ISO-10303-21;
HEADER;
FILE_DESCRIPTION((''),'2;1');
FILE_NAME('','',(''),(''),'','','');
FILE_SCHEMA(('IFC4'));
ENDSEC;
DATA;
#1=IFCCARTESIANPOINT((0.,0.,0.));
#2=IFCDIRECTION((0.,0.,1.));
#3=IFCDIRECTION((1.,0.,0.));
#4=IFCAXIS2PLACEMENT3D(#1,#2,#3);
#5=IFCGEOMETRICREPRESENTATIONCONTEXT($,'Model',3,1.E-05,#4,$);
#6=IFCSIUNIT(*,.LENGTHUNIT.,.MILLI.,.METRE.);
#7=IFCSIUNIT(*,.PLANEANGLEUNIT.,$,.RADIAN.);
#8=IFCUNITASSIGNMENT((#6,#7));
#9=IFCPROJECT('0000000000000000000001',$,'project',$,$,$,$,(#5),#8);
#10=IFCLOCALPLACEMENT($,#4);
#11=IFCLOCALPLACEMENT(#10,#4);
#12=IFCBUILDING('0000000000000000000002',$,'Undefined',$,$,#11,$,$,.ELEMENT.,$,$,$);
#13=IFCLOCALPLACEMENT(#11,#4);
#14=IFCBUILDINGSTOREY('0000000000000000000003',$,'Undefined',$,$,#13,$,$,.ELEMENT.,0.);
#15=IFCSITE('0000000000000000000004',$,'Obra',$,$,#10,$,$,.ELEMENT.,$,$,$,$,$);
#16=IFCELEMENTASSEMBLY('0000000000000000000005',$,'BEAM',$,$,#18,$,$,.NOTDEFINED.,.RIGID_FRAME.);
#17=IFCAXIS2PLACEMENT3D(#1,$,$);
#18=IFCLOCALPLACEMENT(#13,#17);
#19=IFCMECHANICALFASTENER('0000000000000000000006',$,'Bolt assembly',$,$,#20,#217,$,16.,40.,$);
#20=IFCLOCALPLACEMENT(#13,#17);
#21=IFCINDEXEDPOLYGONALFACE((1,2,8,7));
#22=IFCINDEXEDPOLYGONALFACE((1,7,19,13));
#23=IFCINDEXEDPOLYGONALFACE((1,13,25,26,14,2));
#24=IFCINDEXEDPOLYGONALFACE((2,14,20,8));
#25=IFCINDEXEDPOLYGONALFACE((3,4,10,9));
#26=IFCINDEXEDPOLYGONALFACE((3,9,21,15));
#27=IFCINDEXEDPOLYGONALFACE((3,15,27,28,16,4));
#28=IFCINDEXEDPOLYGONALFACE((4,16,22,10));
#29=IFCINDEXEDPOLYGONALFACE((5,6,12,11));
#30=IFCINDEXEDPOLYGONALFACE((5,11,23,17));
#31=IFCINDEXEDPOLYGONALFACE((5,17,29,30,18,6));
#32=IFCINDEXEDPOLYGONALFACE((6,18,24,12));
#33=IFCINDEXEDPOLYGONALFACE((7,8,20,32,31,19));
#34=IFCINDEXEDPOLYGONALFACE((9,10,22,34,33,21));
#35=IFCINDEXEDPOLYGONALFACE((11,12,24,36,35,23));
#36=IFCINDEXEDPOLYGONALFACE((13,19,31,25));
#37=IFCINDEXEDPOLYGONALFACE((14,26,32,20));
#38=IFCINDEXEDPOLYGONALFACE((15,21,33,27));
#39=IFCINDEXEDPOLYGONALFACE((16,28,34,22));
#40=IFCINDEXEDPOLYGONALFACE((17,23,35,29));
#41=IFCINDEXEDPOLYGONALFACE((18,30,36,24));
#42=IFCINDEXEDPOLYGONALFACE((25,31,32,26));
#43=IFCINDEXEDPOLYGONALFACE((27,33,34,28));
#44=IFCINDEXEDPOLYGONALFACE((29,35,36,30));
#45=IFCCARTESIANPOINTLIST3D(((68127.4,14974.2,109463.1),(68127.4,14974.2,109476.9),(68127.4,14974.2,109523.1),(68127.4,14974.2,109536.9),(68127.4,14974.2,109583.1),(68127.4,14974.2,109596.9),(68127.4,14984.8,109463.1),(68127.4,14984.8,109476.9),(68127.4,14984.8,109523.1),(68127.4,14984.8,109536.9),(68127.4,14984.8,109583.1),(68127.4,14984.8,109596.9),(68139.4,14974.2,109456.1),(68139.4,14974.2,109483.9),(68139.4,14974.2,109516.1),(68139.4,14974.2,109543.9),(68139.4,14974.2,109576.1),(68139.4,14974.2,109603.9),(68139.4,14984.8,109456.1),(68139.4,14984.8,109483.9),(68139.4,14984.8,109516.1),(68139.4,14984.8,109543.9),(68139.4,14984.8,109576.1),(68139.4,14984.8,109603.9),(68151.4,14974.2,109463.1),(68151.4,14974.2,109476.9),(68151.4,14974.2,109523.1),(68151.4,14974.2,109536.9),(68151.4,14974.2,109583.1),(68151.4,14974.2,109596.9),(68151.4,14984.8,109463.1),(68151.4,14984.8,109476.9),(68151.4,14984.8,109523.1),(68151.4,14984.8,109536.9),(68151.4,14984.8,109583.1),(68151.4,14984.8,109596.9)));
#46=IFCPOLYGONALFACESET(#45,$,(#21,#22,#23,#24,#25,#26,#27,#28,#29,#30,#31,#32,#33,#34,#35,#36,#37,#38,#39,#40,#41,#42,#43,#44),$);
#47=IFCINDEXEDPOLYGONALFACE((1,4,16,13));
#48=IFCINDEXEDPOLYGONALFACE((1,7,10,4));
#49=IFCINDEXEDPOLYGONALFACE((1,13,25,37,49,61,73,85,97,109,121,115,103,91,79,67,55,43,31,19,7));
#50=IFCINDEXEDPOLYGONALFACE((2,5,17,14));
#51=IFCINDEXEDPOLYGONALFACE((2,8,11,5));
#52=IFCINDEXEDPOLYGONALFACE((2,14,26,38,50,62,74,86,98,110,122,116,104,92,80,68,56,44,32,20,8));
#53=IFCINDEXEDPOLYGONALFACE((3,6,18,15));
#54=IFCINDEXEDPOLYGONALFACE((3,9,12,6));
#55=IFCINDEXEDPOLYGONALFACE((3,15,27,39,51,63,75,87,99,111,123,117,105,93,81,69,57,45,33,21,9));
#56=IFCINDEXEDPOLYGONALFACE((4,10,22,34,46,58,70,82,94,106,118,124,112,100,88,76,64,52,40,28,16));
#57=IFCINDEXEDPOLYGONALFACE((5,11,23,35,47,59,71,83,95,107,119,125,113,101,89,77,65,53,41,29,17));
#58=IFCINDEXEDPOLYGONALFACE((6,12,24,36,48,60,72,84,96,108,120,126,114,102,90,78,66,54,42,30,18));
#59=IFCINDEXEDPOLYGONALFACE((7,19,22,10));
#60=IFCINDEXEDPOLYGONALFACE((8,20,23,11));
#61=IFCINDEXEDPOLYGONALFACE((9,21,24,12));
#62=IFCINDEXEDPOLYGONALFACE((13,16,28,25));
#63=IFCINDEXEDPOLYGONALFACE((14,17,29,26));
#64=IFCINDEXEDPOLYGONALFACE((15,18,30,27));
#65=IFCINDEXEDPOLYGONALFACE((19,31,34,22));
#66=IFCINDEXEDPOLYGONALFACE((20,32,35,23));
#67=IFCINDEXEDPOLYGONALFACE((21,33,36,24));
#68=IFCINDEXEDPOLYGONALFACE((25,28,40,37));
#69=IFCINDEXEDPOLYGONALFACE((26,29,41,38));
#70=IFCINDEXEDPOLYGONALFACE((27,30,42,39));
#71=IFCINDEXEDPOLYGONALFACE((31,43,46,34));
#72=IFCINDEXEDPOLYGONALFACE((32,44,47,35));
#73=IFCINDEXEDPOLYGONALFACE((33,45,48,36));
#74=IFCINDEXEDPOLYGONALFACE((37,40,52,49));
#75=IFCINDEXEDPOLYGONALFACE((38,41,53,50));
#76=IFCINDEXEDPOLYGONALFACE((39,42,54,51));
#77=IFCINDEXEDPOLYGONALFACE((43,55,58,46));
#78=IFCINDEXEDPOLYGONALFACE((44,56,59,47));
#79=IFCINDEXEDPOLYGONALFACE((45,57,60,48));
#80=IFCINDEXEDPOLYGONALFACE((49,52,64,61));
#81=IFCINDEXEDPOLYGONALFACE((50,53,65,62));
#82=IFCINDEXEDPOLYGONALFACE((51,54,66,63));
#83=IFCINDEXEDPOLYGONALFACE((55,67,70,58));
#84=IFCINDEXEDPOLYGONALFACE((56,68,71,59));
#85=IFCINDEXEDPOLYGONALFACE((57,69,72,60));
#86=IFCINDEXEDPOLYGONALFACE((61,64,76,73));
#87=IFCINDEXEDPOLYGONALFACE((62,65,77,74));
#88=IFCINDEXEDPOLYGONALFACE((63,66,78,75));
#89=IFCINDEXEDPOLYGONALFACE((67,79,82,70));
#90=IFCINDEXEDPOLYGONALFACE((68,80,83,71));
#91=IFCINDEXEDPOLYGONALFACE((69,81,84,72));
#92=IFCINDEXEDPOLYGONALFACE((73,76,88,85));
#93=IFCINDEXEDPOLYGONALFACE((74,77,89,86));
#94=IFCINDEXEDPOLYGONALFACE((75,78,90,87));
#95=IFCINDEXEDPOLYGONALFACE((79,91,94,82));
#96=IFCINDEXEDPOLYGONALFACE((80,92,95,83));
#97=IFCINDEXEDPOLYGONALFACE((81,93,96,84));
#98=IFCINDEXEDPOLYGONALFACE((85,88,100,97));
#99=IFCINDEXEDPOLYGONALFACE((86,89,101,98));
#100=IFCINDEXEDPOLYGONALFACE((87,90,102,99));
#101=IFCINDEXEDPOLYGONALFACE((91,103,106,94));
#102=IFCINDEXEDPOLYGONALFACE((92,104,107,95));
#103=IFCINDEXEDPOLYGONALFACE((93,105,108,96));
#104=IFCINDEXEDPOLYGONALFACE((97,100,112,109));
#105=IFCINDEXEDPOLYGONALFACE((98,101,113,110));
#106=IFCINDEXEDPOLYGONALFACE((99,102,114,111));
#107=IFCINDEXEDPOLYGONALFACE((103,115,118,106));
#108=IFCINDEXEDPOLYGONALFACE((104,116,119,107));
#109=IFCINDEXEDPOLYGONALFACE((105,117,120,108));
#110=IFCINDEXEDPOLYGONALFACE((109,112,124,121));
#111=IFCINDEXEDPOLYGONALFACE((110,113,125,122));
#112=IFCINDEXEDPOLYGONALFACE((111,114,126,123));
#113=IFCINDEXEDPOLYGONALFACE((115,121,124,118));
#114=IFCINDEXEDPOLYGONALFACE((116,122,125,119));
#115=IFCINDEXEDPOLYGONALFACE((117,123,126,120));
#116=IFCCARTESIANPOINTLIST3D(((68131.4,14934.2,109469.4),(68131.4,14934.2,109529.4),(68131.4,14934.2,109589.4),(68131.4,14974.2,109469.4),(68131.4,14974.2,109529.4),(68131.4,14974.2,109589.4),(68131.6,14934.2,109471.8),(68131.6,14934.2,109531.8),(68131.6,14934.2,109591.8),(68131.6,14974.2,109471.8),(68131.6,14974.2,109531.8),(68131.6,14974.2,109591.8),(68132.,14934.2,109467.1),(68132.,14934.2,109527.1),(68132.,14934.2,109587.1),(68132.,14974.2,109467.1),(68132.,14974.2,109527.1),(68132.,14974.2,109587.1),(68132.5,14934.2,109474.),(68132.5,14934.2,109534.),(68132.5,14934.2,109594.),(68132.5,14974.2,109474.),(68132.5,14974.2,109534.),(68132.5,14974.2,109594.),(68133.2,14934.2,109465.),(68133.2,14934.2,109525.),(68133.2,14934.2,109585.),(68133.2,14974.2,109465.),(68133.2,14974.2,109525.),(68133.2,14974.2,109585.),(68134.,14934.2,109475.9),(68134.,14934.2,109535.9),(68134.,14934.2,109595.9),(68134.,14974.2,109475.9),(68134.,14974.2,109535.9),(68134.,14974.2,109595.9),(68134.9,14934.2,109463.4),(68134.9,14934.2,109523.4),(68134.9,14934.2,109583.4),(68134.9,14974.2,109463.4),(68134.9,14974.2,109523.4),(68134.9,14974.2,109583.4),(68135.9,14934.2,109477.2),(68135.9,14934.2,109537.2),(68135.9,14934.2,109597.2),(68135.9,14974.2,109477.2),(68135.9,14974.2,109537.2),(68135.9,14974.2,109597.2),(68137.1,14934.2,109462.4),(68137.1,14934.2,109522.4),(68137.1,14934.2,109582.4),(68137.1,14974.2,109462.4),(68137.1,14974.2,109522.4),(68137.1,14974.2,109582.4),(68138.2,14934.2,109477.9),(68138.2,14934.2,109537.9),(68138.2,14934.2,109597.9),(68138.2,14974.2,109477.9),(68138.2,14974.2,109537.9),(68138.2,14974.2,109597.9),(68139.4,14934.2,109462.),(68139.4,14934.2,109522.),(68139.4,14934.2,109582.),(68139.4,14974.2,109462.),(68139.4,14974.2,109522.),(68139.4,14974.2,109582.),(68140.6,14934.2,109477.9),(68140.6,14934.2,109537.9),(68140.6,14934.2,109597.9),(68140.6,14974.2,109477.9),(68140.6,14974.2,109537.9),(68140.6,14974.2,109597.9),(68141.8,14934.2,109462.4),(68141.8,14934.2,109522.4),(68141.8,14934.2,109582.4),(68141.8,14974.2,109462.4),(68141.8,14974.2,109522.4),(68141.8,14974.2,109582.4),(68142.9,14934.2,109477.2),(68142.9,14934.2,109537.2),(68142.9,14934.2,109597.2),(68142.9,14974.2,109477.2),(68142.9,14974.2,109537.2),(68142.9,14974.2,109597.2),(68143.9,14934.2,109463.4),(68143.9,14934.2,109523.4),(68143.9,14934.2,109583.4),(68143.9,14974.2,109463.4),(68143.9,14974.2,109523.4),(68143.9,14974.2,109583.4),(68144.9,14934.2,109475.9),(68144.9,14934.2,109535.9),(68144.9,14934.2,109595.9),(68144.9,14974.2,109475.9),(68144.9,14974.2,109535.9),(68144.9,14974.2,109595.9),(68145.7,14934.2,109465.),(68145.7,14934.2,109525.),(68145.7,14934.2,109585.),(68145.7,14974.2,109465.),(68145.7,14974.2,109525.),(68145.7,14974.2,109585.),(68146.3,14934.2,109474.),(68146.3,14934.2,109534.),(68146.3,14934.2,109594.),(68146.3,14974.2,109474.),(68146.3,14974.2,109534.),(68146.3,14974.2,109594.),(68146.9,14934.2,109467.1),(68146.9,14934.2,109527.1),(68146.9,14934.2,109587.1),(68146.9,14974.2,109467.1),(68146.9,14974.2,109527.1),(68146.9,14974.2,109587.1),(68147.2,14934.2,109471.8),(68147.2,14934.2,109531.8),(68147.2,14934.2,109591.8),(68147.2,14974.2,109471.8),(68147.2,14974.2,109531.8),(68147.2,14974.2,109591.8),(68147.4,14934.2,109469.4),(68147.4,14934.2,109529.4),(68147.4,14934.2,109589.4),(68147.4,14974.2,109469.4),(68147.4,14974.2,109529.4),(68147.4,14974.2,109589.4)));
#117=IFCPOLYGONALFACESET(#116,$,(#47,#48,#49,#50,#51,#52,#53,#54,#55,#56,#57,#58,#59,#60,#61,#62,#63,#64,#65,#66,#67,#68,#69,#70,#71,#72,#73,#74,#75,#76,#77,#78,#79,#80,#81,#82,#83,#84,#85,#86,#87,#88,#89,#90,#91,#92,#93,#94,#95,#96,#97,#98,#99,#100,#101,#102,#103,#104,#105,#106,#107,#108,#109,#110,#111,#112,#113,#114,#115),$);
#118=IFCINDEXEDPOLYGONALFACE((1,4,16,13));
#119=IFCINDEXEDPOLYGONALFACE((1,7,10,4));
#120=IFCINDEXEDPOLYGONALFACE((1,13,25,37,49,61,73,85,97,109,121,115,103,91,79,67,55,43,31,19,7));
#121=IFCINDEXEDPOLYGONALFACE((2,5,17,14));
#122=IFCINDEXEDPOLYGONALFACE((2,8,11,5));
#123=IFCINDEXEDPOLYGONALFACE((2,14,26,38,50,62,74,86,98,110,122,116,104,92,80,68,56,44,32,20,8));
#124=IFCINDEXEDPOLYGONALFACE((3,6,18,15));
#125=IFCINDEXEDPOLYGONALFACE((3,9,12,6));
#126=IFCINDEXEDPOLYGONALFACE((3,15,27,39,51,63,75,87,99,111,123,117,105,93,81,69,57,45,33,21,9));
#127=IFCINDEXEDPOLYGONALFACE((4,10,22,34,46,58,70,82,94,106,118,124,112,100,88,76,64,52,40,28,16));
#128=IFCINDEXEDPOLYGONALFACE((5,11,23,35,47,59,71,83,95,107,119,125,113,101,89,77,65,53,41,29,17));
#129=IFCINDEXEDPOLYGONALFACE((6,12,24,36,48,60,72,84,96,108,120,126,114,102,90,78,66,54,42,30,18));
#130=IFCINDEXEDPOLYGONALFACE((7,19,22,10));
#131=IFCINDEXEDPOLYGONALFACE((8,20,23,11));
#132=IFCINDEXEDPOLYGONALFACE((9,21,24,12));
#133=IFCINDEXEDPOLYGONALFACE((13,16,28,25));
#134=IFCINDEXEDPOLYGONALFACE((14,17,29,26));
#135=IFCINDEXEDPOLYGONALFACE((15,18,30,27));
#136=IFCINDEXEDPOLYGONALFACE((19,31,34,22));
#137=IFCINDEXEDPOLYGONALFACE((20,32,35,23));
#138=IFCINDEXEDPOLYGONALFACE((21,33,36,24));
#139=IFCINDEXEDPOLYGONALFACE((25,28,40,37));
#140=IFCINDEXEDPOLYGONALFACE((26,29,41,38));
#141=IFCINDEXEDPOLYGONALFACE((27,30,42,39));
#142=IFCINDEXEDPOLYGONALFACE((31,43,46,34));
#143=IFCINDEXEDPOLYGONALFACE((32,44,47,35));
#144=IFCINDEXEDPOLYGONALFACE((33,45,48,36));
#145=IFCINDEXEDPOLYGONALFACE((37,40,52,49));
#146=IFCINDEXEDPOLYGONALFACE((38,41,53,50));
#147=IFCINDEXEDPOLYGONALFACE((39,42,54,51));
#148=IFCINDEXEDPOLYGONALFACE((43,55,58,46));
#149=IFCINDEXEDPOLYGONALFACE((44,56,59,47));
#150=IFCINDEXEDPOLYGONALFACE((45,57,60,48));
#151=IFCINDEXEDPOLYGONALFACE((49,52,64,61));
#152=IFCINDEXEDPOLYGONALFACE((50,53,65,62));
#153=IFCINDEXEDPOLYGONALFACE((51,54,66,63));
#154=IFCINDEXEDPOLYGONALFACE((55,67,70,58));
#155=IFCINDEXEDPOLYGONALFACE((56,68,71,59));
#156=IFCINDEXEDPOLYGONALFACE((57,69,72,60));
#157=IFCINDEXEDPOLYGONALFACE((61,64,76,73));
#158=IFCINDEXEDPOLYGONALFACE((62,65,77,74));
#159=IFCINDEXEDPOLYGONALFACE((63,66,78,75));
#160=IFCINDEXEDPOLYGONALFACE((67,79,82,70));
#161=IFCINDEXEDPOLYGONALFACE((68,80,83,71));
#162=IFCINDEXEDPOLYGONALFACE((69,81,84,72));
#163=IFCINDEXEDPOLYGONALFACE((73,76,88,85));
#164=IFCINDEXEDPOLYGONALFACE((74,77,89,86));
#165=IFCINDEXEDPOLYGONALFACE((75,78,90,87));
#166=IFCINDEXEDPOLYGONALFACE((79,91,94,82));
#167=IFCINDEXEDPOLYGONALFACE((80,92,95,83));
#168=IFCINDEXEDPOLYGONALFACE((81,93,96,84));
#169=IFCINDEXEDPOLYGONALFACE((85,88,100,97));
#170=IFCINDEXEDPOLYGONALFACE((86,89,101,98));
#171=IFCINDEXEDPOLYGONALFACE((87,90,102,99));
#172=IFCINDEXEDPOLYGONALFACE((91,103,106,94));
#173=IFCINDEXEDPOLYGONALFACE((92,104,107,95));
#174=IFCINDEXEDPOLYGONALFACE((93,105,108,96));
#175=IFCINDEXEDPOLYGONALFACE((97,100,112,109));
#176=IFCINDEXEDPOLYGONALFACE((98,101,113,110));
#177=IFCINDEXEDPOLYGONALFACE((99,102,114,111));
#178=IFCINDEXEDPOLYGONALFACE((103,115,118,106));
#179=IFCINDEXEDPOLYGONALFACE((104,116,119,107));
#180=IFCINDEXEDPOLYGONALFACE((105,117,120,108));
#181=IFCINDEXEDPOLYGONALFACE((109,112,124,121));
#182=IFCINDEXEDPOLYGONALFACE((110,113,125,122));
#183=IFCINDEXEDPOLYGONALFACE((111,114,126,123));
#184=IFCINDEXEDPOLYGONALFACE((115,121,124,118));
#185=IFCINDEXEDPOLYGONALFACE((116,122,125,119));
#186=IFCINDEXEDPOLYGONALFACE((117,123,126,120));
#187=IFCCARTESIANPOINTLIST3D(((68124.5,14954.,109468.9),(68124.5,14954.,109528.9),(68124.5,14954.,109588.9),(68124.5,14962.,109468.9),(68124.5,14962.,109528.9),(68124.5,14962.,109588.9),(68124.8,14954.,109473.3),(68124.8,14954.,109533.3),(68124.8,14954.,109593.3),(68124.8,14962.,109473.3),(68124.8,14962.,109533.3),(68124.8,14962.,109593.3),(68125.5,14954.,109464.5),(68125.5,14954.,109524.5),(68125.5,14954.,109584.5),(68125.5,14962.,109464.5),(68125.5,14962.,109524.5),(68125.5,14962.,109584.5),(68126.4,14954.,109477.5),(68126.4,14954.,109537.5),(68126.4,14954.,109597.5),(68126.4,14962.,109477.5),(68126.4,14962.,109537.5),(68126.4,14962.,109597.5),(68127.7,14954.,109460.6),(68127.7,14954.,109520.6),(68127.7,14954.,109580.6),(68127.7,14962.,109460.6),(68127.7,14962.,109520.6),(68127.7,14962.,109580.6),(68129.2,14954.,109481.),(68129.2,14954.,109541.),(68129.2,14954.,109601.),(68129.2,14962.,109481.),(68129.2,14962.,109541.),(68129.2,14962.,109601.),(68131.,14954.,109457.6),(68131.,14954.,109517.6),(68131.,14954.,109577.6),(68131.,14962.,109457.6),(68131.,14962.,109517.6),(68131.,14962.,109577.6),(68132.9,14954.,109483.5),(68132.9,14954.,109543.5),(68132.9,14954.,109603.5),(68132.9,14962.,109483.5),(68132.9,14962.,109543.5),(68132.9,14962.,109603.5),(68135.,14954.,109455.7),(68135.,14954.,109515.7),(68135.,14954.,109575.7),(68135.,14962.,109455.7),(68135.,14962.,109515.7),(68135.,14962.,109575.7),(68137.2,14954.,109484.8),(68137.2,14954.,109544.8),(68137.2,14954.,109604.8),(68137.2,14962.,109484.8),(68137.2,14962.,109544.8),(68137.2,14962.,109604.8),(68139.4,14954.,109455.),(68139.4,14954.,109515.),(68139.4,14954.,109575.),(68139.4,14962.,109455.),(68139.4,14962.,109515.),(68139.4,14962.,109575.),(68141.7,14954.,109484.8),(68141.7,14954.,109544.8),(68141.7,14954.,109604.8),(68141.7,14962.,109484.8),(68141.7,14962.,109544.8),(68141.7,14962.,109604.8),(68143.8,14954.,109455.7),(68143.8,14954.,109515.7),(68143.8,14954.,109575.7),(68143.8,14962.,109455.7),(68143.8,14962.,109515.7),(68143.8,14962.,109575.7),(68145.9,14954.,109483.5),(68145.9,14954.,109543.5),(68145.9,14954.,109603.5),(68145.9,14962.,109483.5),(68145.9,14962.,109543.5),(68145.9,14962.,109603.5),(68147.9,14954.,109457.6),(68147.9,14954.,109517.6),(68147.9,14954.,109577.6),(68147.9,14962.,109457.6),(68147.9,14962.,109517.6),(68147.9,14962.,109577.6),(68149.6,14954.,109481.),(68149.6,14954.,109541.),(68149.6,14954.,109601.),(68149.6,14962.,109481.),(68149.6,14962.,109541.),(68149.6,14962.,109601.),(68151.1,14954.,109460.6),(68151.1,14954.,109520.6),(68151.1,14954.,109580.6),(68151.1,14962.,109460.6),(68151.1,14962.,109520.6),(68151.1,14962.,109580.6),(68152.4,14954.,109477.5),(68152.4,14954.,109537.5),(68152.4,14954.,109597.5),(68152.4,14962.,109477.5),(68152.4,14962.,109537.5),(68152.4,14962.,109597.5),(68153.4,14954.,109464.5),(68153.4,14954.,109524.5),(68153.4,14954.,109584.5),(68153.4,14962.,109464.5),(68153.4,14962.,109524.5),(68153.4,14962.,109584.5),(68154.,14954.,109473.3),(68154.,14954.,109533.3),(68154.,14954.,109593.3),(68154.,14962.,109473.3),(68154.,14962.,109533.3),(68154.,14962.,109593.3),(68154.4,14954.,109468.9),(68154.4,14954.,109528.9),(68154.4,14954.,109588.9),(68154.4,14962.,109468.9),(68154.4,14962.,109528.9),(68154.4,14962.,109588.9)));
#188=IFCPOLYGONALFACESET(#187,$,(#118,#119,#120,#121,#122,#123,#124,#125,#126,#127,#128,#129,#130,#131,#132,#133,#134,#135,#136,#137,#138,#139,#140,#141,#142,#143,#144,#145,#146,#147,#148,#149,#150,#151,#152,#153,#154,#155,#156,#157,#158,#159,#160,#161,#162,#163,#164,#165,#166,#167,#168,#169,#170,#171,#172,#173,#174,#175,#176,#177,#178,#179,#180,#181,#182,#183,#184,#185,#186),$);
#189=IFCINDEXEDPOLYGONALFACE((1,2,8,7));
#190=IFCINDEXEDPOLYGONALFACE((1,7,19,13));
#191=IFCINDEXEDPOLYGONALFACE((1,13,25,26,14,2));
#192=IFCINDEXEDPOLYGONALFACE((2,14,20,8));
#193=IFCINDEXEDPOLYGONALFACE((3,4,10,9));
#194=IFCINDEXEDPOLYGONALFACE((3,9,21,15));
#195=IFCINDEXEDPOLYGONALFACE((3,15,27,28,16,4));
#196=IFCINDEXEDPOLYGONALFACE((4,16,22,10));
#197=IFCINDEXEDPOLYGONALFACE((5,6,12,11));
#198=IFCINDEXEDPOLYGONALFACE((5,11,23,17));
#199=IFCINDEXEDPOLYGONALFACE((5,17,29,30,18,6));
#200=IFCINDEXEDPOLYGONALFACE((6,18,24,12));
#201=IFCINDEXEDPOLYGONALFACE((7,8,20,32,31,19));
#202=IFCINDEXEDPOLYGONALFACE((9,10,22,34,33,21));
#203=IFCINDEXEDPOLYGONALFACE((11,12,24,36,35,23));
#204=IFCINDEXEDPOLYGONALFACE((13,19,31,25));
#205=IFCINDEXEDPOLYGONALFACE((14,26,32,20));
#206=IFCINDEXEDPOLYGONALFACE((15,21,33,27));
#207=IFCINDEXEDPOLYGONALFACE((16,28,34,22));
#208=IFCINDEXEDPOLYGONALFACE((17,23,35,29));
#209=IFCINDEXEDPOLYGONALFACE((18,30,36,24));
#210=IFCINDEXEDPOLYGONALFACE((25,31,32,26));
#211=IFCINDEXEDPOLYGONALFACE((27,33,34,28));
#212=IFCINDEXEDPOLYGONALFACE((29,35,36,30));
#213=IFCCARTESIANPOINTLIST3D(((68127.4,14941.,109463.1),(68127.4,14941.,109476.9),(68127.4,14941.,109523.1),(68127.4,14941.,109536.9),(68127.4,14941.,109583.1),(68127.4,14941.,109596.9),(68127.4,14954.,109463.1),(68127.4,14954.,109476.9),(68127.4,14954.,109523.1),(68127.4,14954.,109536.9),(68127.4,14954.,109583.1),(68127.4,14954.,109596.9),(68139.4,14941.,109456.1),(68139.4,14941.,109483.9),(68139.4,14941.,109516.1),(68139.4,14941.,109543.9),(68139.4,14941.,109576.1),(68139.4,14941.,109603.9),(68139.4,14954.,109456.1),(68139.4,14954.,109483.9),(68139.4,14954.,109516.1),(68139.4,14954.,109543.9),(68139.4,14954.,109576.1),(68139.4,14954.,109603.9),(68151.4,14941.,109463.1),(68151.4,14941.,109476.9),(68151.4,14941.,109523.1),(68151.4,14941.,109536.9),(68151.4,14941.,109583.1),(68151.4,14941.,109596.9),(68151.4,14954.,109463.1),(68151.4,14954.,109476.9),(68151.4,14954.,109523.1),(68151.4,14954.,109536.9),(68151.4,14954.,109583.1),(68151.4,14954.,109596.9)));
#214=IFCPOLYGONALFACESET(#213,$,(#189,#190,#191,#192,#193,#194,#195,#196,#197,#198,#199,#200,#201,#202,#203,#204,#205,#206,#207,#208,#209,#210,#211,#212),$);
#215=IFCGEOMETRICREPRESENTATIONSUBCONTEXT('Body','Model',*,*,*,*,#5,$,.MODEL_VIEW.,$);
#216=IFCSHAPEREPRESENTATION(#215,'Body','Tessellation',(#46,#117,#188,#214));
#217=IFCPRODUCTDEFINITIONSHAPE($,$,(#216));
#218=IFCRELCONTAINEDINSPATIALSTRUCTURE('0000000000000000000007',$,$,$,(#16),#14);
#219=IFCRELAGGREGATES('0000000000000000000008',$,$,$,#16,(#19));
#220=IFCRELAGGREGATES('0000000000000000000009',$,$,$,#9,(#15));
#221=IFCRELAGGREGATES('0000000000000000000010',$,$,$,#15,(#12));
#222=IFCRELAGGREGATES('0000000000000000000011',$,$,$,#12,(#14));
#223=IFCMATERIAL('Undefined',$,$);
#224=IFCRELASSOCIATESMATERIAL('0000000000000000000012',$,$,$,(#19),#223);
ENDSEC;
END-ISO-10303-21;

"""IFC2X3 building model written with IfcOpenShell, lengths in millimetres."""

from ifc_helpers import new_model, si_unit, frame, origin_with_axes, origin_2d_with_axis, place, context, subcontext, project, spatial, polyline, circle, outline, extrude, source, transform, mapped, material, element, aggregate, save


model = new_model("IFC2X3")

# Units and contexts
model_context = context("Model", 3, precision=1e-05, world=origin_with_axes())
body_context = subcontext(model_context, "Body", "Model", "MODEL_VIEW")
ifc_project = project(units=[si_unit("LENGTHUNIT", "METRE", prefix="MILLI"), si_unit("PLANEANGLEUNIT", "RADIAN")], contexts=[model_context])

# Site, building, storey
site_placement = place(None, origin_with_axes())
site = spatial("IfcSite", under=ifc_project, at=site_placement, Name="Obra", CompositionType="ELEMENT")
building_placement = place(site_placement, origin_with_axes())
building = spatial("IfcBuilding", under=site, at=building_placement, Name="Undefined", CompositionType="ELEMENT")
storey_placement = place(building_placement, origin_with_axes())
storey = spatial("IfcBuildingStorey", under=building, at=storey_placement, Name="Undefined", CompositionType="ELEMENT", Elevation=0.0)

# Shared definitions
ifc_material_1 = material(Name="Undefined")

# Element assembly, mechanical fastener
shared_shape_1 = source(origin_with_axes(), body_context, "Body", "SweptSolid", [
    extrude(outline(polyline([(13.9, 0.0), (6.9, 12.0), (-6.9, 12.0), (-13.9, 0.0), (-6.9, -12.0), (6.9, -12.0), (13.9, 0.0)])), frame((0.0, -19.7, 0.0), z_axis=(0.0, 1.0, 0.0), x_axis=(1.0, 0.0, 0.0)), (0.0, 0.0, 1.0), 10.6),
    extrude(circle(Radius=8.0, at=origin_2d_with_axis()), frame((0.0, -9.1, 0.0), z_axis=(0.0, 1.0, 0.0), x_axis=(1.0, 0.0, 0.0)), (0.0, 0.0, 1.0), 40.0),
    extrude(circle(Radius=15.0, at=origin_2d_with_axis()), frame((0.0, 3.1, 0.0), z_axis=(0.0, 1.0, 0.0), x_axis=(1.0, 0.0, 0.0)), (0.0, 0.0, 1.0), 8.0),
    extrude(outline(polyline([(13.9, 0.0), (6.9, 12.0), (-6.9, 12.0), (-13.9, 0.0), (-6.9, -12.0), (6.9, -12.0), (13.9, 0.0)])), frame((0.0, 11.1, 0.0), z_axis=(0.0, 1.0, 0.0), x_axis=(1.0, 0.0, 0.0)), (0.0, 0.0, 1.0), 13.0),
])
assembly_1_placement = place(storey_placement, origin_with_axes())
assembly_1 = element("IfcElementAssembly", 1, at=assembly_1_placement, inside=storey, Name="BEAM", AssemblyPlace="NOTDEFINED", PredefinedType="RIGID_FRAME")
mechanical_fastener_1_placement = place(assembly_1_placement, frame((68189.4, 14965.1, 109650.0), z_axis=(-1.0, 0.000126, 0.0), x_axis=(0.0, 0.0, -1.0)))
mechanical_fastener_1 = element("IfcMechanicalFastener", 2, at=mechanical_fastener_1_placement, material=ifc_material_1, Name="Bolt assembly", NominalDiameter=16.0, NominalLength=40.0, context=body_context, shape_type="MappedRepresentation", body=[
    mapped(shared_shape_1, transform((60.0, 0.0, 50.0))),
    mapped(shared_shape_1, transform((120.0, 0.0, 50.0))),
    mapped(shared_shape_1, transform((180.0, 0.0, 50.0))),
])
aggregate(assembly_1, [mechanical_fastener_1])

save(model, "model.ifc")
